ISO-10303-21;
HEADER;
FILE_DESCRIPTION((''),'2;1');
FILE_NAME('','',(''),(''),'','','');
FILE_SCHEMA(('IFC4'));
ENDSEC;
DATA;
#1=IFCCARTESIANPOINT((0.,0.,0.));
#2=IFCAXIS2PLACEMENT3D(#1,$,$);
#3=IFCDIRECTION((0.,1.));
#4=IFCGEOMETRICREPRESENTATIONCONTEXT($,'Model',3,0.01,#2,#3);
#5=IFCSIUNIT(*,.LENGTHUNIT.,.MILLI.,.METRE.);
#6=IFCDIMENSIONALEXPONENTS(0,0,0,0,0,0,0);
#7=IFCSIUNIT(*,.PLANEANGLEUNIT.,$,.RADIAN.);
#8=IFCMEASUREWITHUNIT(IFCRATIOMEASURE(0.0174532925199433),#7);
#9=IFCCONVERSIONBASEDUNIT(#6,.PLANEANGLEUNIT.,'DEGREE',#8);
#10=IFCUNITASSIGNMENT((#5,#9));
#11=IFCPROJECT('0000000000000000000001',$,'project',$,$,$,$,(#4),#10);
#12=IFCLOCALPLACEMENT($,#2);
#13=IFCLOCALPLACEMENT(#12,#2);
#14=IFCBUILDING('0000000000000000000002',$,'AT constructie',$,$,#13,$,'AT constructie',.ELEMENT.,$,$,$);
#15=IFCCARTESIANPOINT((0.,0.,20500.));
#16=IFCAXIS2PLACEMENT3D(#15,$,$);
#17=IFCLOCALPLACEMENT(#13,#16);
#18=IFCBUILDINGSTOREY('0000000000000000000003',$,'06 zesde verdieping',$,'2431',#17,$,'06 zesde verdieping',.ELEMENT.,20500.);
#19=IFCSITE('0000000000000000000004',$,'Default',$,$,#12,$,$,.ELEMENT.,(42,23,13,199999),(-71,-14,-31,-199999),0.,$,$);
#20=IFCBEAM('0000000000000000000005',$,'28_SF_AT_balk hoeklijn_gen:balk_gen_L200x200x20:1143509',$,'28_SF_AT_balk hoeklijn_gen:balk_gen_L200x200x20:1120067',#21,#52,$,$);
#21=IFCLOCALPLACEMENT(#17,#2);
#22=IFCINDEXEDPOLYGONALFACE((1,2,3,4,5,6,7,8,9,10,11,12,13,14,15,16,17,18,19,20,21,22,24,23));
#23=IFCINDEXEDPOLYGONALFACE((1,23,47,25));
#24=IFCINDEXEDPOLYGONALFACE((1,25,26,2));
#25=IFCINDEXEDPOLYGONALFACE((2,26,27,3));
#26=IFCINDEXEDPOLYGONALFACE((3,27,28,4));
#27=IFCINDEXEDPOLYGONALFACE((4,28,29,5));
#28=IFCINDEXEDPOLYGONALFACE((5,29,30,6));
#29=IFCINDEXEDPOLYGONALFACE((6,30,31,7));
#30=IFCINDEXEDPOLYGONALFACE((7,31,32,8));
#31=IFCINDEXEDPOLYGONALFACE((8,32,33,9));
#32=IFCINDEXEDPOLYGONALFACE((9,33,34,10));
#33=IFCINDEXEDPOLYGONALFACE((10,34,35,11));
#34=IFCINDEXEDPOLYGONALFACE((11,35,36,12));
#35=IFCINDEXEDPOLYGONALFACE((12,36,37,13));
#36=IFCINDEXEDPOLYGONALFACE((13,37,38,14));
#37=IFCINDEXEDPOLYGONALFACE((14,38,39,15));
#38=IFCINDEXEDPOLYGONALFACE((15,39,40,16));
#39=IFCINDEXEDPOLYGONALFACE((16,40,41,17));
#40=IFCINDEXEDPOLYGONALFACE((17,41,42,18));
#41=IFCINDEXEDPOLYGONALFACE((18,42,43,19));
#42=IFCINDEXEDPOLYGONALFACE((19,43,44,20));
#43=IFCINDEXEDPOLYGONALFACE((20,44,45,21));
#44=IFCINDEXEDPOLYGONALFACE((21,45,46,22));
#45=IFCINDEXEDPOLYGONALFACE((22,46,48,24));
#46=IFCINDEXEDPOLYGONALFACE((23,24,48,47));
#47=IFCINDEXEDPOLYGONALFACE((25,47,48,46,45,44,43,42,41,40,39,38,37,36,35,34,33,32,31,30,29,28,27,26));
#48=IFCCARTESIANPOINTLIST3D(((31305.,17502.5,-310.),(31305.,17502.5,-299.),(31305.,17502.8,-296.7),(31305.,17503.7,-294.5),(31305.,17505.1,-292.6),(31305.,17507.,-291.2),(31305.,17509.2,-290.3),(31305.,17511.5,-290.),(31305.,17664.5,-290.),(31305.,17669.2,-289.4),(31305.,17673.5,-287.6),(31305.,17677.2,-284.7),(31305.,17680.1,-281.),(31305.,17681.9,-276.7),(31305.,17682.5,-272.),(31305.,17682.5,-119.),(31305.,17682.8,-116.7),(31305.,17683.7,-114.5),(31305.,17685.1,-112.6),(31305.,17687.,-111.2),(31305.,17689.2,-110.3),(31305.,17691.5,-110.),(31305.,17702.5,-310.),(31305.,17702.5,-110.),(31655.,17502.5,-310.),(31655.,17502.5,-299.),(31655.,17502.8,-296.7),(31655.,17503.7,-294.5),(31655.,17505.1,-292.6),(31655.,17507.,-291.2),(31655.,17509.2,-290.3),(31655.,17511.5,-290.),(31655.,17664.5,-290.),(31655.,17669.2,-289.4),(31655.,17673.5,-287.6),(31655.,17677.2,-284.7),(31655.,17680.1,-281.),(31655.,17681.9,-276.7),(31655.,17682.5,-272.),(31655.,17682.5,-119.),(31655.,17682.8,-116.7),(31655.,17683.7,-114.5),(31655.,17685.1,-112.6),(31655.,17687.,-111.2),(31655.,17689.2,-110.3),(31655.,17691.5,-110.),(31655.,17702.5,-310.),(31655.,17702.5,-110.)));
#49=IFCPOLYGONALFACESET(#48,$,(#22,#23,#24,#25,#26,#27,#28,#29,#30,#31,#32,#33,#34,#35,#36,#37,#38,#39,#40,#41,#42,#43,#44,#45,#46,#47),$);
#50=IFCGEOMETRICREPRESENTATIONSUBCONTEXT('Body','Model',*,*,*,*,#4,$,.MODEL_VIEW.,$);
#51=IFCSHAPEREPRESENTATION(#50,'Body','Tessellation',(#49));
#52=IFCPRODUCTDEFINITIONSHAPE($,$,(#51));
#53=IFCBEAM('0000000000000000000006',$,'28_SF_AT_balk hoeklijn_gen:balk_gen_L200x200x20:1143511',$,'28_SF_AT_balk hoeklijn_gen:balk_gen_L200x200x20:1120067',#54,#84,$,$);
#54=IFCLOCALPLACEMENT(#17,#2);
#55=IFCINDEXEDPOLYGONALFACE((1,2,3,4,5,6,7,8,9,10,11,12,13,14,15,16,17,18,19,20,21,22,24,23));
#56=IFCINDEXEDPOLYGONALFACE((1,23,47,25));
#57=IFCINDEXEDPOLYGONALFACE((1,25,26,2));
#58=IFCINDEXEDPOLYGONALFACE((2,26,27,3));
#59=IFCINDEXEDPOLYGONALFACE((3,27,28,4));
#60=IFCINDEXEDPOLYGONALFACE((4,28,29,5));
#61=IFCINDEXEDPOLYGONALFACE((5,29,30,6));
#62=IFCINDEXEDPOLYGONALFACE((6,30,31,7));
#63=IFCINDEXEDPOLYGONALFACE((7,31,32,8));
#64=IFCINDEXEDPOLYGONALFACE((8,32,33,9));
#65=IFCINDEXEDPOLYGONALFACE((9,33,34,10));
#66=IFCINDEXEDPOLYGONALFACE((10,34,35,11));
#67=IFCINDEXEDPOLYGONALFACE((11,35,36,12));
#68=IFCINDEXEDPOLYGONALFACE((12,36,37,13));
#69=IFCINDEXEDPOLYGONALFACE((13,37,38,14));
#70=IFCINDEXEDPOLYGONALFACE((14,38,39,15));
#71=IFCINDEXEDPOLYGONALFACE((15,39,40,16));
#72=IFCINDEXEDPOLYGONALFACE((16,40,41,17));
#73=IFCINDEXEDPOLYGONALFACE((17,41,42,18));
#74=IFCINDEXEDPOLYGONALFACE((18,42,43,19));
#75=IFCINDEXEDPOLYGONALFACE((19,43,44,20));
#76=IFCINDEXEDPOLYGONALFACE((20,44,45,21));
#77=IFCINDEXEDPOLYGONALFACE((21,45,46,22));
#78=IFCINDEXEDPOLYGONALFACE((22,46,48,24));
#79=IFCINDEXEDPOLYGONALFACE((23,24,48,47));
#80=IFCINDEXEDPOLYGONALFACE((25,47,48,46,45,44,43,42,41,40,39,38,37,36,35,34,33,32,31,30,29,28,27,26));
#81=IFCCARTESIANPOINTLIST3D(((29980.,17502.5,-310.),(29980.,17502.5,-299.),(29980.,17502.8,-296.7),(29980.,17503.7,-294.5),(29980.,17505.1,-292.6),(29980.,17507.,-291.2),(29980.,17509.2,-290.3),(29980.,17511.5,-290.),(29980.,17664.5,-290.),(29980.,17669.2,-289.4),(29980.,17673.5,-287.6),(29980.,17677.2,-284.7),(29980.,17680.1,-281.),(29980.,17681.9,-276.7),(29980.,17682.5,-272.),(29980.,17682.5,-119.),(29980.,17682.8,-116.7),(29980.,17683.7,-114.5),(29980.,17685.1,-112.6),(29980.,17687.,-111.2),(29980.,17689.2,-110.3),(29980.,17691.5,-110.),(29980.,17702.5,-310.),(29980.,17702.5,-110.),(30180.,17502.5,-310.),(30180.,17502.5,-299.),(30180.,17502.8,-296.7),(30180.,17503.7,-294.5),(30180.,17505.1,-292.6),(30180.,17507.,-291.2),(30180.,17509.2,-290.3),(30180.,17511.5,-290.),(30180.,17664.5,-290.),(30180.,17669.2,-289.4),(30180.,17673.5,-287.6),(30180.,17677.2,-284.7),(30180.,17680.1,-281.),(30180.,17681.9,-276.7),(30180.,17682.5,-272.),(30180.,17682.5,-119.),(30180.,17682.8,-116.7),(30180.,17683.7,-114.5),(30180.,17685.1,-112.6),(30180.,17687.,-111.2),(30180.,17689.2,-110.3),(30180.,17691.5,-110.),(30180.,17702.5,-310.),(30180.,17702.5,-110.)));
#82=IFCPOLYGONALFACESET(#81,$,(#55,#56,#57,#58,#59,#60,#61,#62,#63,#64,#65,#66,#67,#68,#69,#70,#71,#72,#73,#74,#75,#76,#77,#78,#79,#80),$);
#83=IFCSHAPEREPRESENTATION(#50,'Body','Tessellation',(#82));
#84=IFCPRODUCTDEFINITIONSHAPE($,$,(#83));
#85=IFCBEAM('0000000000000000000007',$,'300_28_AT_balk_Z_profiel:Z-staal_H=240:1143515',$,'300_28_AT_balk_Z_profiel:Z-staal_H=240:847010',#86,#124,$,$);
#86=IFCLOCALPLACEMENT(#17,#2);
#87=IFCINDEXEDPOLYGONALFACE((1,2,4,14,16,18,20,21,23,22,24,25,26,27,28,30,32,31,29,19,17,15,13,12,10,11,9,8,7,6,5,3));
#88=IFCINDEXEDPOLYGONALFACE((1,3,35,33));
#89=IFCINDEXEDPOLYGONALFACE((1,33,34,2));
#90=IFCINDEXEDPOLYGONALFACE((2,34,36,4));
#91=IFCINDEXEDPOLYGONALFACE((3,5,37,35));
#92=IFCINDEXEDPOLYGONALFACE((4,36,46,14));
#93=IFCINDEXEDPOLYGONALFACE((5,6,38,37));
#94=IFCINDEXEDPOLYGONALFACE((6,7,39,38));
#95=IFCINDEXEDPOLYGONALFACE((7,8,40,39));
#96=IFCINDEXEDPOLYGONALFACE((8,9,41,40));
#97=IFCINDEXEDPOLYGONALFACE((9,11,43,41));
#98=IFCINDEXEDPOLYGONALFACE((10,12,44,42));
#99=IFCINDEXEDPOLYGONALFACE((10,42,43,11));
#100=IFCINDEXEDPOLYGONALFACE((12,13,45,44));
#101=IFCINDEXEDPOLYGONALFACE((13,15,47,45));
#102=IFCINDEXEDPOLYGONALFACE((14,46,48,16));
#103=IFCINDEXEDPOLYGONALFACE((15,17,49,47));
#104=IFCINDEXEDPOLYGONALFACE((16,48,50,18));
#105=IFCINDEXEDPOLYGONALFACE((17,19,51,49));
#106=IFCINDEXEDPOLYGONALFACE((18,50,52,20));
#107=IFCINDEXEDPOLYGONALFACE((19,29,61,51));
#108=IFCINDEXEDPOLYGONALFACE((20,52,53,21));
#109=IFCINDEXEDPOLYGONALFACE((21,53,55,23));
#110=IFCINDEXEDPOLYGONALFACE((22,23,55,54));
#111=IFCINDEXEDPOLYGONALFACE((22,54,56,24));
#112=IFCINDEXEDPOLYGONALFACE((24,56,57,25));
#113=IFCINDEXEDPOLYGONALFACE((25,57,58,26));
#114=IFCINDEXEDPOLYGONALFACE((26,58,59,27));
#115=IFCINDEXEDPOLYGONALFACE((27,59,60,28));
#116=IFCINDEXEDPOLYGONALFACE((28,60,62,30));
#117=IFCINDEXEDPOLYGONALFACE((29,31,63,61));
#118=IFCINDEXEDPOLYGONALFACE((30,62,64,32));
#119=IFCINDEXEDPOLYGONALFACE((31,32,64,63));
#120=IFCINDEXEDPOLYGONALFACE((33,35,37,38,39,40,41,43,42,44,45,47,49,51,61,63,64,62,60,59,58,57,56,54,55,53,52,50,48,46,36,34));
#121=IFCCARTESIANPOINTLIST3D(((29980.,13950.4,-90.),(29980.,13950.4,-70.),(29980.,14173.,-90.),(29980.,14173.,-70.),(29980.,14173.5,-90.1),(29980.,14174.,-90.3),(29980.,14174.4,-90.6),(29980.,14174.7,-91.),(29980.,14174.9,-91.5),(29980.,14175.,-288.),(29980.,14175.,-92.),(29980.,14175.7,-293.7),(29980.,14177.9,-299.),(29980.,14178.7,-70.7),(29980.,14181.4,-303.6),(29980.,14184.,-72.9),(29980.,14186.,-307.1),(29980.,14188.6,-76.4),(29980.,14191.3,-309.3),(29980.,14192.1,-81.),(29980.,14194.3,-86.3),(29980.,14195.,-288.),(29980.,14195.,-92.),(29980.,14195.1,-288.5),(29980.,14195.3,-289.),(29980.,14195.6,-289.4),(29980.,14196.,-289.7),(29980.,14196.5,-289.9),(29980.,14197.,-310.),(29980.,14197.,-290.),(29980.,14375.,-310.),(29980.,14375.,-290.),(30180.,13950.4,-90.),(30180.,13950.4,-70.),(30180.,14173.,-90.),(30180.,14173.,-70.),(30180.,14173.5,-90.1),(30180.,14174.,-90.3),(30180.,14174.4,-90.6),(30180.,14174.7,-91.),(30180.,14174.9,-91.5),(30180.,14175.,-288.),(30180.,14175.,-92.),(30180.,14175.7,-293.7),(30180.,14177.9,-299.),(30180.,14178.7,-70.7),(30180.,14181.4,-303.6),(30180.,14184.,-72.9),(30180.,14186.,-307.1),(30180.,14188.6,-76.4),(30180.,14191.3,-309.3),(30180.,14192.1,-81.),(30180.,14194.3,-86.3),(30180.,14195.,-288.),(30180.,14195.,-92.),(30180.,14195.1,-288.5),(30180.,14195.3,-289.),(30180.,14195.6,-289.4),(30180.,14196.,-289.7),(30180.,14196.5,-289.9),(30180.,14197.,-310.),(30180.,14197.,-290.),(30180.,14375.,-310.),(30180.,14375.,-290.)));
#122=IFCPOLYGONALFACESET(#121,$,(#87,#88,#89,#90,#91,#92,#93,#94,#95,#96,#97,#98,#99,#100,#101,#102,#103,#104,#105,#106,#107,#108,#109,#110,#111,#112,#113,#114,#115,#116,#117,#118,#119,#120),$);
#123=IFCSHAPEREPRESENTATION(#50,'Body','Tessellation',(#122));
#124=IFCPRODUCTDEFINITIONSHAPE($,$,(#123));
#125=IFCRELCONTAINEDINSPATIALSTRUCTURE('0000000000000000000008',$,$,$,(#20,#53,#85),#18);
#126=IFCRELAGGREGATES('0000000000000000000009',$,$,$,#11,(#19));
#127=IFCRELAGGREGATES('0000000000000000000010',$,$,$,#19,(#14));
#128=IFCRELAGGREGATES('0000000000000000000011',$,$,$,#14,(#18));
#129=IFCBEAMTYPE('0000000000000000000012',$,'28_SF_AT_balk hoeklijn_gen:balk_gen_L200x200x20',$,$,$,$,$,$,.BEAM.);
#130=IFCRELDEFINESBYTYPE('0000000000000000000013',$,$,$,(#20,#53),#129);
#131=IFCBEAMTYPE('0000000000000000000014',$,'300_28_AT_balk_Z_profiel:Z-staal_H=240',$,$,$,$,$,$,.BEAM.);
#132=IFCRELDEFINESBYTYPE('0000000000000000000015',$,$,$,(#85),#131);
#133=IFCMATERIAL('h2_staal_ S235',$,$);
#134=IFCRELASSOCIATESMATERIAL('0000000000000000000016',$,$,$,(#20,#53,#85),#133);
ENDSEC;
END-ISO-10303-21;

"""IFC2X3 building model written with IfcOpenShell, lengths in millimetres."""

from ifc_helpers import new_model, entity, si_unit, converted_unit, direction, frame, frame_2d, origin, place, context, subcontext, project, spatial, polyline, circle_curve, parameter, trimmed, segment, composite_curve, outline, extrude, material, type_object, element, save


model = new_model("IFC2X3")

# Units and contexts
model_context = context("Model", 3, precision=0.01, world=origin(), true_north=direction((0.0, 1.0)))
body_context = subcontext(model_context, "Body", "Model", "MODEL_VIEW")
ifc_project = project(units=[si_unit("LENGTHUNIT", "METRE", prefix="MILLI"), converted_unit("PLANEANGLEUNIT", "DEGREE", entity("IfcRatioMeasure", 0.0174532925199433), si_unit("PLANEANGLEUNIT", "RADIAN"), dimensions=[0, 0, 0, 0, 0, 0, 0])], contexts=[model_context])

# Site, building, storey
site_placement = place(None, origin())
site = spatial("IfcSite", under=ifc_project, at=site_placement, Name="Default", CompositionType="ELEMENT", RefLatitude=(42, 23, 13, 199999), RefLongitude=(-71, -14, -31, -199999), RefElevation=0.0)
building_placement = place(site_placement, origin())
building = spatial("IfcBuilding", under=site, at=building_placement, Name="AT constructie", LongName="AT constructie", CompositionType="ELEMENT")
storey_placement = place(building_placement, frame((0.0, 0.0, 20500.0)))
storey = spatial("IfcBuildingStorey", under=building, at=storey_placement, Name="06 zesde verdieping", ObjectType="2431", LongName="06 zesde verdieping", CompositionType="ELEMENT", Elevation=20500.0)

# Beams
ifc_material_1 = material(Name="h2_staal_ S235")
beam_type_1 = type_object("IfcBeamType", Name="28_SF_AT_balk hoeklijn_gen:balk_gen_L200x200x20", PredefinedType="BEAM")
beam_1_placement = place(storey_placement, frame((31655.0, 17702.5, -70.0), z_axis=(0.0, 0.0, 1.0), x_axis=(-1.0, 0.0, 0.0)))
element("IfcBeam", 1, at=beam_1_placement, inside=storey, type_object=beam_type_1, material=ifc_material_1, Name="28_SF_AT_balk hoeklijn_gen:balk_gen_L200x200x20:1143509", ObjectType="28_SF_AT_balk hoeklijn_gen:balk_gen_L200x200x20:1120067", context=body_context, shape_type="SweptSolid", body=[
    extrude(outline(composite_curve([segment(polyline([(-124.4, -75.6), (75.6, -75.6)]), True, "CONTINUOUS"), segment(polyline([(75.6, -75.6), (75.6, 124.4)]), True, "CONTINUOUS"), segment(polyline([(75.6, 124.4), (64.6, 124.4)]), True, "CONTINUOUS"), segment(trimmed(circle_curve(frame_2d((64.6, 115.4), x_axis=(0.0, 1.0)), 9.0), [parameter(0.0)], [parameter(90.0)], True, "PARAMETER"), True, "CONTINUOUS"), segment(polyline([(55.6, 115.4), (55.6, -37.6)]), True, "CONTINUOUS"), segment(trimmed(circle_curve(frame_2d((37.6, -37.6), x_axis=(1.0, 0.0)), 18.0), [parameter(270.0)], [parameter(0.0)], True, "PARAMETER"), False, "CONTINUOUS"), segment(polyline([(37.6, -55.6), (-115.4, -55.6)]), True, "CONTINUOUS"), segment(trimmed(circle_curve(frame_2d((-115.4, -64.6), x_axis=(0.0, 1.0)), 9.0), [parameter(0.0)], [parameter(90.0)], True, "PARAMETER"), True, "CONTINUOUS"), segment(polyline([(-124.4, -64.6), (-124.4, -75.6)]), True, "CONTINUOUS")], self_intersect=False)), frame((0.0, 75.6, -164.4), z_axis=(1.0, 0.0, 0.0), x_axis=(0.0, 0.0, -1.0)), (0.0, 0.0, 1.0), 350.0),
])
beam_2_placement = place(storey_placement, frame((30180.0, 17702.5, -70.0), z_axis=(0.0, 0.0, 1.0), x_axis=(-1.0, 0.0, 0.0)))
element("IfcBeam", 2, at=beam_2_placement, inside=storey, type_object=beam_type_1, material=ifc_material_1, Name="28_SF_AT_balk hoeklijn_gen:balk_gen_L200x200x20:1143511", ObjectType="28_SF_AT_balk hoeklijn_gen:balk_gen_L200x200x20:1120067", context=body_context, shape_type="SweptSolid", body=[
    extrude(outline(composite_curve([segment(polyline([(-124.4, -75.6), (75.6, -75.6)]), True, "CONTINUOUS"), segment(polyline([(75.6, -75.6), (75.6, 124.4)]), True, "CONTINUOUS"), segment(polyline([(75.6, 124.4), (64.6, 124.4)]), True, "CONTINUOUS"), segment(trimmed(circle_curve(frame_2d((64.6, 115.4), x_axis=(0.0, 1.0)), 9.0), [parameter(0.0)], [parameter(90.0)], True, "PARAMETER"), True, "CONTINUOUS"), segment(polyline([(55.6, 115.4), (55.6, -37.6)]), True, "CONTINUOUS"), segment(trimmed(circle_curve(frame_2d((37.6, -37.6), x_axis=(1.0, 0.0)), 18.0), [parameter(270.0)], [parameter(0.0)], True, "PARAMETER"), False, "CONTINUOUS"), segment(polyline([(37.6, -55.6), (-115.4, -55.6)]), True, "CONTINUOUS"), segment(trimmed(circle_curve(frame_2d((-115.4, -64.6), x_axis=(0.0, 1.0)), 9.0), [parameter(0.0)], [parameter(90.0)], True, "PARAMETER"), True, "CONTINUOUS"), segment(polyline([(-124.4, -64.6), (-124.4, -75.6)]), True, "CONTINUOUS")], self_intersect=False)), frame((0.0, 75.6, -164.4), z_axis=(1.0, 0.0, 0.0), x_axis=(0.0, 0.0, -1.0)), (0.0, 0.0, 1.0), 200.0),
])
beam_type_2 = type_object("IfcBeamType", Name="300_28_AT_balk_Z_profiel:Z-staal_H=240", PredefinedType="BEAM")
beam_3_placement = place(storey_placement, frame((30180.0, 14175.0, -70.0), z_axis=(0.0, 0.0, 1.0), x_axis=(-1.0, 0.0, 0.0)))
element("IfcBeam", 3, at=beam_3_placement, inside=storey, type_object=beam_type_2, material=ifc_material_1, Name="300_28_AT_balk_Z_profiel:Z-staal_H=240:1143515", ObjectType="300_28_AT_balk_Z_profiel:Z-staal_H=240:847010", context=body_context, shape_type="SweptSolid", body=[
    extrude(outline(composite_curve([segment(polyline([(100.0, -197.4), (120.0, -197.4)]), True, "CONTINUOUS"), segment(polyline([(120.0, -197.4), (120.0, -19.4)]), True, "CONTINUOUS"), segment(trimmed(circle_curve(frame_2d((98.0, -19.4), x_axis=(1.0, 0.0)), 22.0), [parameter(0.0)], [parameter(90.0)], True, "PARAMETER"), True, "CONTINUOUS"), segment(polyline([(98.0, 2.6), (-98.0, 2.6)]), True, "CONTINUOUS"), segment(trimmed(circle_curve(frame_2d((-98.0, 4.6), x_axis=(0.0, -1.0)), 2.0), [parameter(270.0)], [parameter(0.0)], True, "PARAMETER"), False, "CONTINUOUS"), segment(polyline([(-100.0, 4.6), (-100.0, 227.2)]), True, "CONTINUOUS"), segment(polyline([(-100.0, 227.2), (-120.0, 227.2)]), True, "CONTINUOUS"), segment(polyline([(-120.0, 227.2), (-120.0, 4.6)]), True, "CONTINUOUS"), segment(trimmed(circle_curve(frame_2d((-98.0, 4.6), x_axis=(-1.0, 0.0)), 22.0), [parameter(0.0)], [parameter(90.0)], True, "PARAMETER"), True, "CONTINUOUS"), segment(polyline([(-98.0, -17.4), (98.0, -17.4)]), True, "CONTINUOUS"), segment(trimmed(circle_curve(frame_2d((98.0, -19.4), x_axis=(0.0, 1.0)), 2.0), [parameter(270.0)], [parameter(0.0)], True, "PARAMETER"), False, "CONTINUOUS"), segment(polyline([(100.0, -19.4), (100.0, -197.4)]), True, "CONTINUOUS")], self_intersect=False)), frame((0.0, -2.6, -120.0), z_axis=(1.0, 0.0, 0.0), x_axis=(0.0, 0.0, -1.0)), (0.0, 0.0, 1.0), 200.0),
])

save(model, "model.ifc")
